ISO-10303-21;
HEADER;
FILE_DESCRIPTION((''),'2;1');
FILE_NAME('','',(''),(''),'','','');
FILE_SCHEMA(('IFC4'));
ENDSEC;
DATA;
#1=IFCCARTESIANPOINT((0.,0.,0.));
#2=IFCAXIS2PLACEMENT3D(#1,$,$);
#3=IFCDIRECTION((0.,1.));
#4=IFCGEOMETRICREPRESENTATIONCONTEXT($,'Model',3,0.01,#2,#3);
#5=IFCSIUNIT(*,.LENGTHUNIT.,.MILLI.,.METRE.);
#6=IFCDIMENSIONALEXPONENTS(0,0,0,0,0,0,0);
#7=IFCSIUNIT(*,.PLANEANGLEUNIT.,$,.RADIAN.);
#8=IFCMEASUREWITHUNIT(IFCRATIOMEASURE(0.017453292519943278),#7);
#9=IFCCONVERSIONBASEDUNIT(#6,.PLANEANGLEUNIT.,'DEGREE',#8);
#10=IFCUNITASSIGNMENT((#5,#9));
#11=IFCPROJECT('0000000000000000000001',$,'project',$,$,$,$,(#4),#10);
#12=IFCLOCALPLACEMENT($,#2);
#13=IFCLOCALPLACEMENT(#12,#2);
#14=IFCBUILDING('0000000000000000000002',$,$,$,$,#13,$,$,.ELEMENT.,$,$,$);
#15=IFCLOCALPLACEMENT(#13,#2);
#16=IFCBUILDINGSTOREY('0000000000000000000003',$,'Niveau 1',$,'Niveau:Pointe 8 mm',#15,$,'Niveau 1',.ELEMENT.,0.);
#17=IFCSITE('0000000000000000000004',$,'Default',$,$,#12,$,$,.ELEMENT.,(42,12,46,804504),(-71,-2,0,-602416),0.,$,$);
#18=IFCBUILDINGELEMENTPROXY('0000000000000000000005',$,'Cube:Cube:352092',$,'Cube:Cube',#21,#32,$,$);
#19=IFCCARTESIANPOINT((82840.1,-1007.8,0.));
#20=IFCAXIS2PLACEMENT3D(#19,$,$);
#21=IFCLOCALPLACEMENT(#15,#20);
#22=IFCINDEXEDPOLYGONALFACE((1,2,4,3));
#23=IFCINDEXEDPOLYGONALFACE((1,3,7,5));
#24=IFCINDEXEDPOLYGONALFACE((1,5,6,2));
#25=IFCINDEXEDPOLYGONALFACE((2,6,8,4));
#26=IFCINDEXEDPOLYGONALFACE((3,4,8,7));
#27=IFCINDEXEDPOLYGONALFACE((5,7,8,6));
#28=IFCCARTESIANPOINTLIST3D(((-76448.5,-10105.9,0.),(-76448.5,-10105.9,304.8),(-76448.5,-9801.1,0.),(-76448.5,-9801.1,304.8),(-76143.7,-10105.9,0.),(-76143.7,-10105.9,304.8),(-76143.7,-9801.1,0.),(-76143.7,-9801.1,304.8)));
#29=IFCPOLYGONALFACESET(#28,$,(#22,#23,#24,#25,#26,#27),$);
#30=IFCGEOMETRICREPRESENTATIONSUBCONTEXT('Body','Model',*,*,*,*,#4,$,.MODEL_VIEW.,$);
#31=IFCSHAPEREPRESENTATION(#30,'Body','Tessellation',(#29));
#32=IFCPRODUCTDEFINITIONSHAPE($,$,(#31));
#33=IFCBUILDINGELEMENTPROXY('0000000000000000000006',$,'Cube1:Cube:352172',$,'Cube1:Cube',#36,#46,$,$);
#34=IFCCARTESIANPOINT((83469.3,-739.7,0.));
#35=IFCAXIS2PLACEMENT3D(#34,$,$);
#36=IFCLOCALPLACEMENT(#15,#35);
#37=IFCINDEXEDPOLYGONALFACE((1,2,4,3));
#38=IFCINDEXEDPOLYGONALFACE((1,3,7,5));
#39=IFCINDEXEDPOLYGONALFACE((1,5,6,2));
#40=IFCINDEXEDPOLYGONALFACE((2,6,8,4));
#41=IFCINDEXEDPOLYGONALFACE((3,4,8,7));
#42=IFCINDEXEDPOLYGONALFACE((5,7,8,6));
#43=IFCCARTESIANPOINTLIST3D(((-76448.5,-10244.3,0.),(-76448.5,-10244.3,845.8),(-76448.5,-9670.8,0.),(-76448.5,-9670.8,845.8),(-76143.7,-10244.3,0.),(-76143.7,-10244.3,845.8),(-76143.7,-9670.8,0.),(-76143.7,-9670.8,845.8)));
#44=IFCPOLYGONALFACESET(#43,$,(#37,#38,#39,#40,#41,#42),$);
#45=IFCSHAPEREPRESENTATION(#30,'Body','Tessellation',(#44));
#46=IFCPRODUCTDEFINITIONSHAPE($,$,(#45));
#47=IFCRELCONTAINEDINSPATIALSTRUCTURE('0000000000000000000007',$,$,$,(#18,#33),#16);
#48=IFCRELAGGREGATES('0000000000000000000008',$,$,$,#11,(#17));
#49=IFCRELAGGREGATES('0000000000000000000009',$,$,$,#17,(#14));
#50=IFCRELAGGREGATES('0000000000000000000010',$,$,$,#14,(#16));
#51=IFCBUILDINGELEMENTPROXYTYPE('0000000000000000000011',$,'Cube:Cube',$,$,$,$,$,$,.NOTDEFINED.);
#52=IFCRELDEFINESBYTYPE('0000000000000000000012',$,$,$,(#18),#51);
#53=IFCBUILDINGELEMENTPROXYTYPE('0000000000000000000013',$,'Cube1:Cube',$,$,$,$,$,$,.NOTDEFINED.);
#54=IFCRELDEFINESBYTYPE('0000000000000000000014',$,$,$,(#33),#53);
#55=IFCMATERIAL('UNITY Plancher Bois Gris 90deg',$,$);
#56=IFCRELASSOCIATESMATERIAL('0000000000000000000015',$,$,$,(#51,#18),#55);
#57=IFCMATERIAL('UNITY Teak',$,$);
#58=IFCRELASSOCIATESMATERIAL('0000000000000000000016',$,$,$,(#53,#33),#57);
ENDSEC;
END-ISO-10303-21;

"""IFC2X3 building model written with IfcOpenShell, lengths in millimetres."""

from ifc_helpers import new_model, entity, si_unit, converted_unit, direction, frame, frame_2d, origin, origin_2d_with_axis, place, context, subcontext, project, spatial, rectangle, extrude, source, transform, mapped, material, type_object, type_shapes, element, save


model = new_model("IFC2X3")

# Units and contexts
model_context = context("Model", 3, precision=0.01, world=origin(), true_north=direction((0.0, 1.0)))
body_context = subcontext(model_context, "Body", "Model", "MODEL_VIEW")
ifc_project = project(units=[si_unit("LENGTHUNIT", "METRE", prefix="MILLI"), converted_unit("PLANEANGLEUNIT", "DEGREE", entity("IfcRatioMeasure", 0.017453292519943278), si_unit("PLANEANGLEUNIT", "RADIAN"), dimensions=[0, 0, 0, 0, 0, 0, 0])], contexts=[model_context])

# Site, building, storey
site_placement = place(None, origin())
site = spatial("IfcSite", under=ifc_project, at=site_placement, Name="Default", CompositionType="ELEMENT", RefLatitude=(42, 12, 46, 804504), RefLongitude=(-71, -2, 0, -602416), RefElevation=0.0)
building_placement = place(site_placement, origin())
building = spatial("IfcBuilding", under=site, at=building_placement, CompositionType="ELEMENT")
storey_placement = place(building_placement, origin())
storey = spatial("IfcBuildingStorey", under=building, at=storey_placement, Name="Niveau 1", ObjectType="Niveau:Pointe 8 mm", LongName="Niveau 1", CompositionType="ELEMENT", Elevation=0.0)

# Building element proxies
ifc_material_1 = material(Name="UNITY Plancher Bois Gris 90deg")
building_element_proxy_type_1 = type_object("IfcBuildingElementProxyType", Name="Cube:Cube", PredefinedType="NOTDEFINED", material=ifc_material_1)
shared_shape_1 = source(origin(), body_context, "Body", "SweptSolid", [
    extrude(rectangle(XDim=304.8, YDim=304.8, at=origin_2d_with_axis()), frame((-76296.1, -9953.5, 0.0), z_axis=(0.0, 0.0, 1.0), x_axis=(0.0, -1.0, 0.0)), (0.0, 0.0, 1.0), 304.8),
])
type_shapes(building_element_proxy_type_1, [shared_shape_1])
proxy_1_placement = place(storey_placement, frame((82840.1, -1007.8, 0.0)))
element("IfcBuildingElementProxy", 1, at=proxy_1_placement, inside=storey, type_object=building_element_proxy_type_1, material=ifc_material_1, Name="Cube:Cube:352092", ObjectType="Cube:Cube", context=body_context, shape_type="MappedRepresentation", body=[
    mapped(shared_shape_1, transform((0.0, 0.0, 0.0), scale=1.0)),
])
ifc_material_2 = material(Name="UNITY Teak")
building_element_proxy_type_2 = type_object("IfcBuildingElementProxyType", Name="Cube1:Cube", PredefinedType="NOTDEFINED", material=ifc_material_2)
shared_shape_2 = source(origin(), body_context, "Body", "SweptSolid", [
    extrude(rectangle(XDim=573.5, YDim=304.8, at=frame_2d((0.0, 0.0), x_axis=(1.0, 0.0))), frame((-76296.1, -9957.5, 0.0), z_axis=(0.0, 0.0, 1.0), x_axis=(0.0, -1.0, 0.0)), (0.0, 0.0, 1.0), 845.8),
])
type_shapes(building_element_proxy_type_2, [shared_shape_2])
proxy_2_placement = place(storey_placement, frame((83469.3, -739.7, 0.0)))
element("IfcBuildingElementProxy", 2, at=proxy_2_placement, inside=storey, type_object=building_element_proxy_type_2, material=ifc_material_2, Name="Cube1:Cube:352172", ObjectType="Cube1:Cube", context=body_context, shape_type="MappedRepresentation", body=[
    mapped(shared_shape_2, transform((0.0, 0.0, 0.0), scale=1.0)),
])

save(model, "model.ifc")
